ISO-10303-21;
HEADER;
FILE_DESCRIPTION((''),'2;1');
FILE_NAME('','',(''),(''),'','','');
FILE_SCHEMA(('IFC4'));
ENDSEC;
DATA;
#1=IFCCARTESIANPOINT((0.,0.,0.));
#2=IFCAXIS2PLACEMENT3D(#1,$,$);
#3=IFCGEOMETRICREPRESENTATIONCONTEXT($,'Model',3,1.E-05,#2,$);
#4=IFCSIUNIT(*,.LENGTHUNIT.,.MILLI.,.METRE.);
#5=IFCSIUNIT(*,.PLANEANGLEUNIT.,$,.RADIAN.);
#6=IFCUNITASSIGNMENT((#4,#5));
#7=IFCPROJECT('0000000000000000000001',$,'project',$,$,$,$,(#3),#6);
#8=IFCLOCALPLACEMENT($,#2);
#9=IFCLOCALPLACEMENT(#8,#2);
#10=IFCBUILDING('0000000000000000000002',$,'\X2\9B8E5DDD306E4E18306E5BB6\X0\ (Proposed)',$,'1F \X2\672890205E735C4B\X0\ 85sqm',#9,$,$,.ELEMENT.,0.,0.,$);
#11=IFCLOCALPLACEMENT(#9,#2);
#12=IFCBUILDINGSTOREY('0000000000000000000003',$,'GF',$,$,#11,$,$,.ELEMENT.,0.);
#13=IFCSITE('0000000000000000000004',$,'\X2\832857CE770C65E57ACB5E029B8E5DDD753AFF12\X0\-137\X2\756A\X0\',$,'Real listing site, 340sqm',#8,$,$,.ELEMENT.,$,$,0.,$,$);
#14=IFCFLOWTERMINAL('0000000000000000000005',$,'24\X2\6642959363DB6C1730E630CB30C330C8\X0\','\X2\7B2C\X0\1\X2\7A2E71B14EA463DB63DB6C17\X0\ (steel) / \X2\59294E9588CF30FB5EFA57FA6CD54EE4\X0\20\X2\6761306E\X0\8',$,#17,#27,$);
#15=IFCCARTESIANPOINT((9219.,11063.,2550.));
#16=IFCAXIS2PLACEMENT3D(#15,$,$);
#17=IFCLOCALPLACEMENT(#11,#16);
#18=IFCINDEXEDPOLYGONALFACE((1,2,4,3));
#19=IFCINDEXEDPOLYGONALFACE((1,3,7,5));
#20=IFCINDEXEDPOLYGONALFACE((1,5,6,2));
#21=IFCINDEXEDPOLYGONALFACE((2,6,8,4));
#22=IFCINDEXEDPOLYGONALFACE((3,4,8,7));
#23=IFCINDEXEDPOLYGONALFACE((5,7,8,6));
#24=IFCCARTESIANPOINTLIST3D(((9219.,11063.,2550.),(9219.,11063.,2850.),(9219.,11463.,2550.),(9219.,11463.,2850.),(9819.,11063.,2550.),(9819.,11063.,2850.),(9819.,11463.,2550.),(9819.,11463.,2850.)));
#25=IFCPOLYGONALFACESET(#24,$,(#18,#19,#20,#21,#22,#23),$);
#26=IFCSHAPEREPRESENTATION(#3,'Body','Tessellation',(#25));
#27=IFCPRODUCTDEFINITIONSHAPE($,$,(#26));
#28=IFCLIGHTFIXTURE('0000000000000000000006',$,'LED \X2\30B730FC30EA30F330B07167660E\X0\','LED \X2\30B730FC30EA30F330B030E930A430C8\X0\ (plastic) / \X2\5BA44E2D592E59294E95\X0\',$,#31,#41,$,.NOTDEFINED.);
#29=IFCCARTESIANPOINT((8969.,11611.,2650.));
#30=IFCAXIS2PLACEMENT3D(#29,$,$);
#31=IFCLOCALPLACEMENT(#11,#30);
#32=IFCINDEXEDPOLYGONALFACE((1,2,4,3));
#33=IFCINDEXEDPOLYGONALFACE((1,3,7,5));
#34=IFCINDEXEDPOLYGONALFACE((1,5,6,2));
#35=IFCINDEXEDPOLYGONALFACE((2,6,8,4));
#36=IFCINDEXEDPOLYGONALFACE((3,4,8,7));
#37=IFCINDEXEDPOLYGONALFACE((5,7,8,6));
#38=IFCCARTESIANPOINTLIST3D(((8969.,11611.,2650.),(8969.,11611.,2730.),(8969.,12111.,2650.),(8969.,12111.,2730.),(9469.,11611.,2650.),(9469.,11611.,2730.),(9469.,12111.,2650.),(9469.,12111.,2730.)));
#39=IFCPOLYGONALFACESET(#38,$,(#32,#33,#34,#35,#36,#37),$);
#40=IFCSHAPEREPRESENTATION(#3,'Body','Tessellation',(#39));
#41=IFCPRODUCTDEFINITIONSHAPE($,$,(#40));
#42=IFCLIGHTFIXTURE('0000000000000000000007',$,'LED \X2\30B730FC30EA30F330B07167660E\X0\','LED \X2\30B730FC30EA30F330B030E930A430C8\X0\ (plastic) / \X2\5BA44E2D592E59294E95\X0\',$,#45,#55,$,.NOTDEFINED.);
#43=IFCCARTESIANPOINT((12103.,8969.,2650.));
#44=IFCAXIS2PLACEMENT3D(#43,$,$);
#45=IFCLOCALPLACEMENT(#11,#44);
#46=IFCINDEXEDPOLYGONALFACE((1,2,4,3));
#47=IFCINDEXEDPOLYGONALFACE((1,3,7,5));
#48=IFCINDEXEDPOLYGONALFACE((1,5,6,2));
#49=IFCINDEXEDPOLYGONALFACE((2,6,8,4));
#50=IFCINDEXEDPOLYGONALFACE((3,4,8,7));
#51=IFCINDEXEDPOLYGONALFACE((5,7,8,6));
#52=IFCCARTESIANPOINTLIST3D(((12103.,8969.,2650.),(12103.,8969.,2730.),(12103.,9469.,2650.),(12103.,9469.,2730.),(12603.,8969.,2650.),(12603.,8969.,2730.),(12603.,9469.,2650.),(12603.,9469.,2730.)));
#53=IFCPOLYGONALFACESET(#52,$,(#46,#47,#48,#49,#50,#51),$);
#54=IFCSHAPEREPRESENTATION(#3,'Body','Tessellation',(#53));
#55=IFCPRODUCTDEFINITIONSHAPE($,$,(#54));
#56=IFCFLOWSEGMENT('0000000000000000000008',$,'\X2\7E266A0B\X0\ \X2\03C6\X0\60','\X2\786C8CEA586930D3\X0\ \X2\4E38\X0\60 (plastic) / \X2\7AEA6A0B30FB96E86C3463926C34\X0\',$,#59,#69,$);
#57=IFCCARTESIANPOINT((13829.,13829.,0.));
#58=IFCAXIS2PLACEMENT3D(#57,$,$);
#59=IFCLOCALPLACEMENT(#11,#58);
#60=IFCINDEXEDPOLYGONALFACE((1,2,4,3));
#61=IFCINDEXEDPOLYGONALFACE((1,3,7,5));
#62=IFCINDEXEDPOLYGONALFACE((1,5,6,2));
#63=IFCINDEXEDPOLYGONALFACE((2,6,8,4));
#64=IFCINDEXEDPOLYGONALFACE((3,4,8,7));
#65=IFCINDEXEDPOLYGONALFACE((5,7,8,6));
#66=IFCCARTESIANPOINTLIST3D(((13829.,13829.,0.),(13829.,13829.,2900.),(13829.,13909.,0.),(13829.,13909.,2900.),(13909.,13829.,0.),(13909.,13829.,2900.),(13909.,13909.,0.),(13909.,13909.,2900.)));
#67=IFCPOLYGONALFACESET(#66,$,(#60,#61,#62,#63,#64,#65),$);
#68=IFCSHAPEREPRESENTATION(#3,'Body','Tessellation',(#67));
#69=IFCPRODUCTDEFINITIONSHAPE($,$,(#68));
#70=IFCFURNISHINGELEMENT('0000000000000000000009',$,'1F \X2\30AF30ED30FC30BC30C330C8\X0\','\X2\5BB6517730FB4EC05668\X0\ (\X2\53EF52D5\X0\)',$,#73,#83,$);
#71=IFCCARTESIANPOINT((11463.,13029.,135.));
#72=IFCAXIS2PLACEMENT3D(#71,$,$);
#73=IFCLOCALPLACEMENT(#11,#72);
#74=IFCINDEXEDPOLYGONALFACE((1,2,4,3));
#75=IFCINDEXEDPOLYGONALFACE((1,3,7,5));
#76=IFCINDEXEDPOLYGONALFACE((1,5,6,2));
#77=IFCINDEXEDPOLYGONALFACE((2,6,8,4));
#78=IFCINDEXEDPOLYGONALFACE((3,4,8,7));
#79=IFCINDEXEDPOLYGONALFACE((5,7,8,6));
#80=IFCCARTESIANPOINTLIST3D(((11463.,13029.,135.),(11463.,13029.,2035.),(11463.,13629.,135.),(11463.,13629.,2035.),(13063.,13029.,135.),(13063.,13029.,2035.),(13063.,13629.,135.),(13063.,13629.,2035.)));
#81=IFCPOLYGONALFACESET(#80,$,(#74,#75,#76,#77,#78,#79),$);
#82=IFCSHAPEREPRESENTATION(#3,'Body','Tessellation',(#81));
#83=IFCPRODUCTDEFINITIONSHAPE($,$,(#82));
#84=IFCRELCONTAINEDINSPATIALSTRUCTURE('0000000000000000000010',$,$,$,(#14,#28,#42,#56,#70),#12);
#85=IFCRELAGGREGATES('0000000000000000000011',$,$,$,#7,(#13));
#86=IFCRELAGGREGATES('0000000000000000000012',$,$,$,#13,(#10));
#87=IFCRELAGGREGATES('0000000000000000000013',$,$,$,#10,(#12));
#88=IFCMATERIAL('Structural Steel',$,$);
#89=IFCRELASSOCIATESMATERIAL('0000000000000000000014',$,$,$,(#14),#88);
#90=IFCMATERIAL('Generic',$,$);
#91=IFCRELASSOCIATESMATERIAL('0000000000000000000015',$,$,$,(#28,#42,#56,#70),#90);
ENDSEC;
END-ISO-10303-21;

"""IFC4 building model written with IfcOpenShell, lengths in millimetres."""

from ifc_helpers import new_model, si_unit, frame, frame_2d, origin, place, context, project, spatial, rectangle, extrude, material, element, save


model = new_model("IFC4")

# Units and contexts
model_context = context("Model", 3, precision=1e-05, world=origin())
ifc_project = project(units=[si_unit("LENGTHUNIT", "METRE", prefix="MILLI"), si_unit("PLANEANGLEUNIT", "RADIAN")], contexts=[model_context])

# Site, building, storey
site_placement = place(None, origin())
site = spatial("IfcSite", under=ifc_project, at=site_placement, Name="茨城県日立市鮎川町２-137番", ObjectType="Real listing site, 340sqm", CompositionType="ELEMENT", RefElevation=0.0)
building_placement = place(site_placement, origin())
building = spatial("IfcBuilding", under=site, at=building_placement, Name="鮎川の丘の家 (Proposed)", ObjectType="1F 木造平屋 85sqm", CompositionType="ELEMENT", ElevationOfRefHeight=0.0, ElevationOfTerrain=0.0)
storey_placement = place(building_placement, origin())
storey = spatial("IfcBuildingStorey", under=building, at=storey_placement, Name="GF", CompositionType="ELEMENT", Elevation=0.0)

# Shared definitions
ifc_material_1 = material(Name="Generic")

# Flow terminal
ifc_material_2 = material(Name="Structural Steel")
flow_terminal_placement = place(storey_placement, frame((9219.0, 11063.0, 2550.0)))
element("IfcFlowTerminal", 1, at=flow_terminal_placement, inside=storey, material=ifc_material_2, Name="24時間換気ユニット", Description="第1種熱交換換気 (steel) / 天井裏・建基法令20条の8", context=model_context, shape_type="SweptSolid", body=[
    extrude(rectangle(XDim=600.0, YDim=400.0, at=frame_2d((300.0, 200.0))), frame((9219.0, 11063.0, 2550.0)), (0.0, 0.0, 1.0), 300.0),
])

# Light fixtures
light_fixture_1_placement = place(storey_placement, frame((8969.0, 11611.0, 2650.0)))
element("IfcLightFixture", 2, at=light_fixture_1_placement, inside=storey, material=ifc_material_1, Name="LED シーリング照明", Description="LED シーリングライト (plastic) / 室中央天井", PredefinedType="NOTDEFINED", context=model_context, shape_type="SweptSolid", body=[
    extrude(rectangle(XDim=500.0, YDim=500.0, at=frame_2d((250.0, 250.0))), frame((8969.0, 11611.0, 2650.0)), (0.0, 0.0, 1.0), 80.0),
])
light_fixture_2_placement = place(storey_placement, frame((12103.0, 8969.0, 2650.0)))
element("IfcLightFixture", 3, at=light_fixture_2_placement, inside=storey, material=ifc_material_1, Name="LED シーリング照明", Description="LED シーリングライト (plastic) / 室中央天井", PredefinedType="NOTDEFINED", context=model_context, shape_type="SweptSolid", body=[
    extrude(rectangle(XDim=500.0, YDim=500.0, at=frame_2d((250.0, 250.0))), frame((12103.0, 8969.0, 2650.0)), (0.0, 0.0, 1.0), 80.0),
])

# Flow segment
flow_segment_placement = place(storey_placement, frame((13829.0, 13829.0, 0.0)))
element("IfcFlowSegment", 4, at=flow_segment_placement, inside=storey, material=ifc_material_1, Name="縦樋 φ60", Description="硬質塩ビ 丸60 (plastic) / 竪樋・雨水排水", context=model_context, shape_type="SweptSolid", body=[
    extrude(rectangle(XDim=80.0, YDim=80.0, at=frame_2d((40.0, 40.0))), frame((13829.0, 13829.0, 0.0)), (0.0, 0.0, 1.0), 2900.0),
])

# Furnishing element
furnishing_placement = place(storey_placement, frame((11463.0, 13029.0, 135.0)))
element("IfcFurnishingElement", 5, at=furnishing_placement, inside=storey, material=ifc_material_1, Name="1F クローゼット", Description="家具・什器 (可動)", context=model_context, shape_type="SweptSolid", body=[
    extrude(rectangle(XDim=1600.0, YDim=600.0, at=frame_2d((800.0, 300.0))), frame((11463.0, 13029.0, 135.0)), (0.0, 0.0, 1.0), 1900.0),
])

save(model, "model.ifc")
